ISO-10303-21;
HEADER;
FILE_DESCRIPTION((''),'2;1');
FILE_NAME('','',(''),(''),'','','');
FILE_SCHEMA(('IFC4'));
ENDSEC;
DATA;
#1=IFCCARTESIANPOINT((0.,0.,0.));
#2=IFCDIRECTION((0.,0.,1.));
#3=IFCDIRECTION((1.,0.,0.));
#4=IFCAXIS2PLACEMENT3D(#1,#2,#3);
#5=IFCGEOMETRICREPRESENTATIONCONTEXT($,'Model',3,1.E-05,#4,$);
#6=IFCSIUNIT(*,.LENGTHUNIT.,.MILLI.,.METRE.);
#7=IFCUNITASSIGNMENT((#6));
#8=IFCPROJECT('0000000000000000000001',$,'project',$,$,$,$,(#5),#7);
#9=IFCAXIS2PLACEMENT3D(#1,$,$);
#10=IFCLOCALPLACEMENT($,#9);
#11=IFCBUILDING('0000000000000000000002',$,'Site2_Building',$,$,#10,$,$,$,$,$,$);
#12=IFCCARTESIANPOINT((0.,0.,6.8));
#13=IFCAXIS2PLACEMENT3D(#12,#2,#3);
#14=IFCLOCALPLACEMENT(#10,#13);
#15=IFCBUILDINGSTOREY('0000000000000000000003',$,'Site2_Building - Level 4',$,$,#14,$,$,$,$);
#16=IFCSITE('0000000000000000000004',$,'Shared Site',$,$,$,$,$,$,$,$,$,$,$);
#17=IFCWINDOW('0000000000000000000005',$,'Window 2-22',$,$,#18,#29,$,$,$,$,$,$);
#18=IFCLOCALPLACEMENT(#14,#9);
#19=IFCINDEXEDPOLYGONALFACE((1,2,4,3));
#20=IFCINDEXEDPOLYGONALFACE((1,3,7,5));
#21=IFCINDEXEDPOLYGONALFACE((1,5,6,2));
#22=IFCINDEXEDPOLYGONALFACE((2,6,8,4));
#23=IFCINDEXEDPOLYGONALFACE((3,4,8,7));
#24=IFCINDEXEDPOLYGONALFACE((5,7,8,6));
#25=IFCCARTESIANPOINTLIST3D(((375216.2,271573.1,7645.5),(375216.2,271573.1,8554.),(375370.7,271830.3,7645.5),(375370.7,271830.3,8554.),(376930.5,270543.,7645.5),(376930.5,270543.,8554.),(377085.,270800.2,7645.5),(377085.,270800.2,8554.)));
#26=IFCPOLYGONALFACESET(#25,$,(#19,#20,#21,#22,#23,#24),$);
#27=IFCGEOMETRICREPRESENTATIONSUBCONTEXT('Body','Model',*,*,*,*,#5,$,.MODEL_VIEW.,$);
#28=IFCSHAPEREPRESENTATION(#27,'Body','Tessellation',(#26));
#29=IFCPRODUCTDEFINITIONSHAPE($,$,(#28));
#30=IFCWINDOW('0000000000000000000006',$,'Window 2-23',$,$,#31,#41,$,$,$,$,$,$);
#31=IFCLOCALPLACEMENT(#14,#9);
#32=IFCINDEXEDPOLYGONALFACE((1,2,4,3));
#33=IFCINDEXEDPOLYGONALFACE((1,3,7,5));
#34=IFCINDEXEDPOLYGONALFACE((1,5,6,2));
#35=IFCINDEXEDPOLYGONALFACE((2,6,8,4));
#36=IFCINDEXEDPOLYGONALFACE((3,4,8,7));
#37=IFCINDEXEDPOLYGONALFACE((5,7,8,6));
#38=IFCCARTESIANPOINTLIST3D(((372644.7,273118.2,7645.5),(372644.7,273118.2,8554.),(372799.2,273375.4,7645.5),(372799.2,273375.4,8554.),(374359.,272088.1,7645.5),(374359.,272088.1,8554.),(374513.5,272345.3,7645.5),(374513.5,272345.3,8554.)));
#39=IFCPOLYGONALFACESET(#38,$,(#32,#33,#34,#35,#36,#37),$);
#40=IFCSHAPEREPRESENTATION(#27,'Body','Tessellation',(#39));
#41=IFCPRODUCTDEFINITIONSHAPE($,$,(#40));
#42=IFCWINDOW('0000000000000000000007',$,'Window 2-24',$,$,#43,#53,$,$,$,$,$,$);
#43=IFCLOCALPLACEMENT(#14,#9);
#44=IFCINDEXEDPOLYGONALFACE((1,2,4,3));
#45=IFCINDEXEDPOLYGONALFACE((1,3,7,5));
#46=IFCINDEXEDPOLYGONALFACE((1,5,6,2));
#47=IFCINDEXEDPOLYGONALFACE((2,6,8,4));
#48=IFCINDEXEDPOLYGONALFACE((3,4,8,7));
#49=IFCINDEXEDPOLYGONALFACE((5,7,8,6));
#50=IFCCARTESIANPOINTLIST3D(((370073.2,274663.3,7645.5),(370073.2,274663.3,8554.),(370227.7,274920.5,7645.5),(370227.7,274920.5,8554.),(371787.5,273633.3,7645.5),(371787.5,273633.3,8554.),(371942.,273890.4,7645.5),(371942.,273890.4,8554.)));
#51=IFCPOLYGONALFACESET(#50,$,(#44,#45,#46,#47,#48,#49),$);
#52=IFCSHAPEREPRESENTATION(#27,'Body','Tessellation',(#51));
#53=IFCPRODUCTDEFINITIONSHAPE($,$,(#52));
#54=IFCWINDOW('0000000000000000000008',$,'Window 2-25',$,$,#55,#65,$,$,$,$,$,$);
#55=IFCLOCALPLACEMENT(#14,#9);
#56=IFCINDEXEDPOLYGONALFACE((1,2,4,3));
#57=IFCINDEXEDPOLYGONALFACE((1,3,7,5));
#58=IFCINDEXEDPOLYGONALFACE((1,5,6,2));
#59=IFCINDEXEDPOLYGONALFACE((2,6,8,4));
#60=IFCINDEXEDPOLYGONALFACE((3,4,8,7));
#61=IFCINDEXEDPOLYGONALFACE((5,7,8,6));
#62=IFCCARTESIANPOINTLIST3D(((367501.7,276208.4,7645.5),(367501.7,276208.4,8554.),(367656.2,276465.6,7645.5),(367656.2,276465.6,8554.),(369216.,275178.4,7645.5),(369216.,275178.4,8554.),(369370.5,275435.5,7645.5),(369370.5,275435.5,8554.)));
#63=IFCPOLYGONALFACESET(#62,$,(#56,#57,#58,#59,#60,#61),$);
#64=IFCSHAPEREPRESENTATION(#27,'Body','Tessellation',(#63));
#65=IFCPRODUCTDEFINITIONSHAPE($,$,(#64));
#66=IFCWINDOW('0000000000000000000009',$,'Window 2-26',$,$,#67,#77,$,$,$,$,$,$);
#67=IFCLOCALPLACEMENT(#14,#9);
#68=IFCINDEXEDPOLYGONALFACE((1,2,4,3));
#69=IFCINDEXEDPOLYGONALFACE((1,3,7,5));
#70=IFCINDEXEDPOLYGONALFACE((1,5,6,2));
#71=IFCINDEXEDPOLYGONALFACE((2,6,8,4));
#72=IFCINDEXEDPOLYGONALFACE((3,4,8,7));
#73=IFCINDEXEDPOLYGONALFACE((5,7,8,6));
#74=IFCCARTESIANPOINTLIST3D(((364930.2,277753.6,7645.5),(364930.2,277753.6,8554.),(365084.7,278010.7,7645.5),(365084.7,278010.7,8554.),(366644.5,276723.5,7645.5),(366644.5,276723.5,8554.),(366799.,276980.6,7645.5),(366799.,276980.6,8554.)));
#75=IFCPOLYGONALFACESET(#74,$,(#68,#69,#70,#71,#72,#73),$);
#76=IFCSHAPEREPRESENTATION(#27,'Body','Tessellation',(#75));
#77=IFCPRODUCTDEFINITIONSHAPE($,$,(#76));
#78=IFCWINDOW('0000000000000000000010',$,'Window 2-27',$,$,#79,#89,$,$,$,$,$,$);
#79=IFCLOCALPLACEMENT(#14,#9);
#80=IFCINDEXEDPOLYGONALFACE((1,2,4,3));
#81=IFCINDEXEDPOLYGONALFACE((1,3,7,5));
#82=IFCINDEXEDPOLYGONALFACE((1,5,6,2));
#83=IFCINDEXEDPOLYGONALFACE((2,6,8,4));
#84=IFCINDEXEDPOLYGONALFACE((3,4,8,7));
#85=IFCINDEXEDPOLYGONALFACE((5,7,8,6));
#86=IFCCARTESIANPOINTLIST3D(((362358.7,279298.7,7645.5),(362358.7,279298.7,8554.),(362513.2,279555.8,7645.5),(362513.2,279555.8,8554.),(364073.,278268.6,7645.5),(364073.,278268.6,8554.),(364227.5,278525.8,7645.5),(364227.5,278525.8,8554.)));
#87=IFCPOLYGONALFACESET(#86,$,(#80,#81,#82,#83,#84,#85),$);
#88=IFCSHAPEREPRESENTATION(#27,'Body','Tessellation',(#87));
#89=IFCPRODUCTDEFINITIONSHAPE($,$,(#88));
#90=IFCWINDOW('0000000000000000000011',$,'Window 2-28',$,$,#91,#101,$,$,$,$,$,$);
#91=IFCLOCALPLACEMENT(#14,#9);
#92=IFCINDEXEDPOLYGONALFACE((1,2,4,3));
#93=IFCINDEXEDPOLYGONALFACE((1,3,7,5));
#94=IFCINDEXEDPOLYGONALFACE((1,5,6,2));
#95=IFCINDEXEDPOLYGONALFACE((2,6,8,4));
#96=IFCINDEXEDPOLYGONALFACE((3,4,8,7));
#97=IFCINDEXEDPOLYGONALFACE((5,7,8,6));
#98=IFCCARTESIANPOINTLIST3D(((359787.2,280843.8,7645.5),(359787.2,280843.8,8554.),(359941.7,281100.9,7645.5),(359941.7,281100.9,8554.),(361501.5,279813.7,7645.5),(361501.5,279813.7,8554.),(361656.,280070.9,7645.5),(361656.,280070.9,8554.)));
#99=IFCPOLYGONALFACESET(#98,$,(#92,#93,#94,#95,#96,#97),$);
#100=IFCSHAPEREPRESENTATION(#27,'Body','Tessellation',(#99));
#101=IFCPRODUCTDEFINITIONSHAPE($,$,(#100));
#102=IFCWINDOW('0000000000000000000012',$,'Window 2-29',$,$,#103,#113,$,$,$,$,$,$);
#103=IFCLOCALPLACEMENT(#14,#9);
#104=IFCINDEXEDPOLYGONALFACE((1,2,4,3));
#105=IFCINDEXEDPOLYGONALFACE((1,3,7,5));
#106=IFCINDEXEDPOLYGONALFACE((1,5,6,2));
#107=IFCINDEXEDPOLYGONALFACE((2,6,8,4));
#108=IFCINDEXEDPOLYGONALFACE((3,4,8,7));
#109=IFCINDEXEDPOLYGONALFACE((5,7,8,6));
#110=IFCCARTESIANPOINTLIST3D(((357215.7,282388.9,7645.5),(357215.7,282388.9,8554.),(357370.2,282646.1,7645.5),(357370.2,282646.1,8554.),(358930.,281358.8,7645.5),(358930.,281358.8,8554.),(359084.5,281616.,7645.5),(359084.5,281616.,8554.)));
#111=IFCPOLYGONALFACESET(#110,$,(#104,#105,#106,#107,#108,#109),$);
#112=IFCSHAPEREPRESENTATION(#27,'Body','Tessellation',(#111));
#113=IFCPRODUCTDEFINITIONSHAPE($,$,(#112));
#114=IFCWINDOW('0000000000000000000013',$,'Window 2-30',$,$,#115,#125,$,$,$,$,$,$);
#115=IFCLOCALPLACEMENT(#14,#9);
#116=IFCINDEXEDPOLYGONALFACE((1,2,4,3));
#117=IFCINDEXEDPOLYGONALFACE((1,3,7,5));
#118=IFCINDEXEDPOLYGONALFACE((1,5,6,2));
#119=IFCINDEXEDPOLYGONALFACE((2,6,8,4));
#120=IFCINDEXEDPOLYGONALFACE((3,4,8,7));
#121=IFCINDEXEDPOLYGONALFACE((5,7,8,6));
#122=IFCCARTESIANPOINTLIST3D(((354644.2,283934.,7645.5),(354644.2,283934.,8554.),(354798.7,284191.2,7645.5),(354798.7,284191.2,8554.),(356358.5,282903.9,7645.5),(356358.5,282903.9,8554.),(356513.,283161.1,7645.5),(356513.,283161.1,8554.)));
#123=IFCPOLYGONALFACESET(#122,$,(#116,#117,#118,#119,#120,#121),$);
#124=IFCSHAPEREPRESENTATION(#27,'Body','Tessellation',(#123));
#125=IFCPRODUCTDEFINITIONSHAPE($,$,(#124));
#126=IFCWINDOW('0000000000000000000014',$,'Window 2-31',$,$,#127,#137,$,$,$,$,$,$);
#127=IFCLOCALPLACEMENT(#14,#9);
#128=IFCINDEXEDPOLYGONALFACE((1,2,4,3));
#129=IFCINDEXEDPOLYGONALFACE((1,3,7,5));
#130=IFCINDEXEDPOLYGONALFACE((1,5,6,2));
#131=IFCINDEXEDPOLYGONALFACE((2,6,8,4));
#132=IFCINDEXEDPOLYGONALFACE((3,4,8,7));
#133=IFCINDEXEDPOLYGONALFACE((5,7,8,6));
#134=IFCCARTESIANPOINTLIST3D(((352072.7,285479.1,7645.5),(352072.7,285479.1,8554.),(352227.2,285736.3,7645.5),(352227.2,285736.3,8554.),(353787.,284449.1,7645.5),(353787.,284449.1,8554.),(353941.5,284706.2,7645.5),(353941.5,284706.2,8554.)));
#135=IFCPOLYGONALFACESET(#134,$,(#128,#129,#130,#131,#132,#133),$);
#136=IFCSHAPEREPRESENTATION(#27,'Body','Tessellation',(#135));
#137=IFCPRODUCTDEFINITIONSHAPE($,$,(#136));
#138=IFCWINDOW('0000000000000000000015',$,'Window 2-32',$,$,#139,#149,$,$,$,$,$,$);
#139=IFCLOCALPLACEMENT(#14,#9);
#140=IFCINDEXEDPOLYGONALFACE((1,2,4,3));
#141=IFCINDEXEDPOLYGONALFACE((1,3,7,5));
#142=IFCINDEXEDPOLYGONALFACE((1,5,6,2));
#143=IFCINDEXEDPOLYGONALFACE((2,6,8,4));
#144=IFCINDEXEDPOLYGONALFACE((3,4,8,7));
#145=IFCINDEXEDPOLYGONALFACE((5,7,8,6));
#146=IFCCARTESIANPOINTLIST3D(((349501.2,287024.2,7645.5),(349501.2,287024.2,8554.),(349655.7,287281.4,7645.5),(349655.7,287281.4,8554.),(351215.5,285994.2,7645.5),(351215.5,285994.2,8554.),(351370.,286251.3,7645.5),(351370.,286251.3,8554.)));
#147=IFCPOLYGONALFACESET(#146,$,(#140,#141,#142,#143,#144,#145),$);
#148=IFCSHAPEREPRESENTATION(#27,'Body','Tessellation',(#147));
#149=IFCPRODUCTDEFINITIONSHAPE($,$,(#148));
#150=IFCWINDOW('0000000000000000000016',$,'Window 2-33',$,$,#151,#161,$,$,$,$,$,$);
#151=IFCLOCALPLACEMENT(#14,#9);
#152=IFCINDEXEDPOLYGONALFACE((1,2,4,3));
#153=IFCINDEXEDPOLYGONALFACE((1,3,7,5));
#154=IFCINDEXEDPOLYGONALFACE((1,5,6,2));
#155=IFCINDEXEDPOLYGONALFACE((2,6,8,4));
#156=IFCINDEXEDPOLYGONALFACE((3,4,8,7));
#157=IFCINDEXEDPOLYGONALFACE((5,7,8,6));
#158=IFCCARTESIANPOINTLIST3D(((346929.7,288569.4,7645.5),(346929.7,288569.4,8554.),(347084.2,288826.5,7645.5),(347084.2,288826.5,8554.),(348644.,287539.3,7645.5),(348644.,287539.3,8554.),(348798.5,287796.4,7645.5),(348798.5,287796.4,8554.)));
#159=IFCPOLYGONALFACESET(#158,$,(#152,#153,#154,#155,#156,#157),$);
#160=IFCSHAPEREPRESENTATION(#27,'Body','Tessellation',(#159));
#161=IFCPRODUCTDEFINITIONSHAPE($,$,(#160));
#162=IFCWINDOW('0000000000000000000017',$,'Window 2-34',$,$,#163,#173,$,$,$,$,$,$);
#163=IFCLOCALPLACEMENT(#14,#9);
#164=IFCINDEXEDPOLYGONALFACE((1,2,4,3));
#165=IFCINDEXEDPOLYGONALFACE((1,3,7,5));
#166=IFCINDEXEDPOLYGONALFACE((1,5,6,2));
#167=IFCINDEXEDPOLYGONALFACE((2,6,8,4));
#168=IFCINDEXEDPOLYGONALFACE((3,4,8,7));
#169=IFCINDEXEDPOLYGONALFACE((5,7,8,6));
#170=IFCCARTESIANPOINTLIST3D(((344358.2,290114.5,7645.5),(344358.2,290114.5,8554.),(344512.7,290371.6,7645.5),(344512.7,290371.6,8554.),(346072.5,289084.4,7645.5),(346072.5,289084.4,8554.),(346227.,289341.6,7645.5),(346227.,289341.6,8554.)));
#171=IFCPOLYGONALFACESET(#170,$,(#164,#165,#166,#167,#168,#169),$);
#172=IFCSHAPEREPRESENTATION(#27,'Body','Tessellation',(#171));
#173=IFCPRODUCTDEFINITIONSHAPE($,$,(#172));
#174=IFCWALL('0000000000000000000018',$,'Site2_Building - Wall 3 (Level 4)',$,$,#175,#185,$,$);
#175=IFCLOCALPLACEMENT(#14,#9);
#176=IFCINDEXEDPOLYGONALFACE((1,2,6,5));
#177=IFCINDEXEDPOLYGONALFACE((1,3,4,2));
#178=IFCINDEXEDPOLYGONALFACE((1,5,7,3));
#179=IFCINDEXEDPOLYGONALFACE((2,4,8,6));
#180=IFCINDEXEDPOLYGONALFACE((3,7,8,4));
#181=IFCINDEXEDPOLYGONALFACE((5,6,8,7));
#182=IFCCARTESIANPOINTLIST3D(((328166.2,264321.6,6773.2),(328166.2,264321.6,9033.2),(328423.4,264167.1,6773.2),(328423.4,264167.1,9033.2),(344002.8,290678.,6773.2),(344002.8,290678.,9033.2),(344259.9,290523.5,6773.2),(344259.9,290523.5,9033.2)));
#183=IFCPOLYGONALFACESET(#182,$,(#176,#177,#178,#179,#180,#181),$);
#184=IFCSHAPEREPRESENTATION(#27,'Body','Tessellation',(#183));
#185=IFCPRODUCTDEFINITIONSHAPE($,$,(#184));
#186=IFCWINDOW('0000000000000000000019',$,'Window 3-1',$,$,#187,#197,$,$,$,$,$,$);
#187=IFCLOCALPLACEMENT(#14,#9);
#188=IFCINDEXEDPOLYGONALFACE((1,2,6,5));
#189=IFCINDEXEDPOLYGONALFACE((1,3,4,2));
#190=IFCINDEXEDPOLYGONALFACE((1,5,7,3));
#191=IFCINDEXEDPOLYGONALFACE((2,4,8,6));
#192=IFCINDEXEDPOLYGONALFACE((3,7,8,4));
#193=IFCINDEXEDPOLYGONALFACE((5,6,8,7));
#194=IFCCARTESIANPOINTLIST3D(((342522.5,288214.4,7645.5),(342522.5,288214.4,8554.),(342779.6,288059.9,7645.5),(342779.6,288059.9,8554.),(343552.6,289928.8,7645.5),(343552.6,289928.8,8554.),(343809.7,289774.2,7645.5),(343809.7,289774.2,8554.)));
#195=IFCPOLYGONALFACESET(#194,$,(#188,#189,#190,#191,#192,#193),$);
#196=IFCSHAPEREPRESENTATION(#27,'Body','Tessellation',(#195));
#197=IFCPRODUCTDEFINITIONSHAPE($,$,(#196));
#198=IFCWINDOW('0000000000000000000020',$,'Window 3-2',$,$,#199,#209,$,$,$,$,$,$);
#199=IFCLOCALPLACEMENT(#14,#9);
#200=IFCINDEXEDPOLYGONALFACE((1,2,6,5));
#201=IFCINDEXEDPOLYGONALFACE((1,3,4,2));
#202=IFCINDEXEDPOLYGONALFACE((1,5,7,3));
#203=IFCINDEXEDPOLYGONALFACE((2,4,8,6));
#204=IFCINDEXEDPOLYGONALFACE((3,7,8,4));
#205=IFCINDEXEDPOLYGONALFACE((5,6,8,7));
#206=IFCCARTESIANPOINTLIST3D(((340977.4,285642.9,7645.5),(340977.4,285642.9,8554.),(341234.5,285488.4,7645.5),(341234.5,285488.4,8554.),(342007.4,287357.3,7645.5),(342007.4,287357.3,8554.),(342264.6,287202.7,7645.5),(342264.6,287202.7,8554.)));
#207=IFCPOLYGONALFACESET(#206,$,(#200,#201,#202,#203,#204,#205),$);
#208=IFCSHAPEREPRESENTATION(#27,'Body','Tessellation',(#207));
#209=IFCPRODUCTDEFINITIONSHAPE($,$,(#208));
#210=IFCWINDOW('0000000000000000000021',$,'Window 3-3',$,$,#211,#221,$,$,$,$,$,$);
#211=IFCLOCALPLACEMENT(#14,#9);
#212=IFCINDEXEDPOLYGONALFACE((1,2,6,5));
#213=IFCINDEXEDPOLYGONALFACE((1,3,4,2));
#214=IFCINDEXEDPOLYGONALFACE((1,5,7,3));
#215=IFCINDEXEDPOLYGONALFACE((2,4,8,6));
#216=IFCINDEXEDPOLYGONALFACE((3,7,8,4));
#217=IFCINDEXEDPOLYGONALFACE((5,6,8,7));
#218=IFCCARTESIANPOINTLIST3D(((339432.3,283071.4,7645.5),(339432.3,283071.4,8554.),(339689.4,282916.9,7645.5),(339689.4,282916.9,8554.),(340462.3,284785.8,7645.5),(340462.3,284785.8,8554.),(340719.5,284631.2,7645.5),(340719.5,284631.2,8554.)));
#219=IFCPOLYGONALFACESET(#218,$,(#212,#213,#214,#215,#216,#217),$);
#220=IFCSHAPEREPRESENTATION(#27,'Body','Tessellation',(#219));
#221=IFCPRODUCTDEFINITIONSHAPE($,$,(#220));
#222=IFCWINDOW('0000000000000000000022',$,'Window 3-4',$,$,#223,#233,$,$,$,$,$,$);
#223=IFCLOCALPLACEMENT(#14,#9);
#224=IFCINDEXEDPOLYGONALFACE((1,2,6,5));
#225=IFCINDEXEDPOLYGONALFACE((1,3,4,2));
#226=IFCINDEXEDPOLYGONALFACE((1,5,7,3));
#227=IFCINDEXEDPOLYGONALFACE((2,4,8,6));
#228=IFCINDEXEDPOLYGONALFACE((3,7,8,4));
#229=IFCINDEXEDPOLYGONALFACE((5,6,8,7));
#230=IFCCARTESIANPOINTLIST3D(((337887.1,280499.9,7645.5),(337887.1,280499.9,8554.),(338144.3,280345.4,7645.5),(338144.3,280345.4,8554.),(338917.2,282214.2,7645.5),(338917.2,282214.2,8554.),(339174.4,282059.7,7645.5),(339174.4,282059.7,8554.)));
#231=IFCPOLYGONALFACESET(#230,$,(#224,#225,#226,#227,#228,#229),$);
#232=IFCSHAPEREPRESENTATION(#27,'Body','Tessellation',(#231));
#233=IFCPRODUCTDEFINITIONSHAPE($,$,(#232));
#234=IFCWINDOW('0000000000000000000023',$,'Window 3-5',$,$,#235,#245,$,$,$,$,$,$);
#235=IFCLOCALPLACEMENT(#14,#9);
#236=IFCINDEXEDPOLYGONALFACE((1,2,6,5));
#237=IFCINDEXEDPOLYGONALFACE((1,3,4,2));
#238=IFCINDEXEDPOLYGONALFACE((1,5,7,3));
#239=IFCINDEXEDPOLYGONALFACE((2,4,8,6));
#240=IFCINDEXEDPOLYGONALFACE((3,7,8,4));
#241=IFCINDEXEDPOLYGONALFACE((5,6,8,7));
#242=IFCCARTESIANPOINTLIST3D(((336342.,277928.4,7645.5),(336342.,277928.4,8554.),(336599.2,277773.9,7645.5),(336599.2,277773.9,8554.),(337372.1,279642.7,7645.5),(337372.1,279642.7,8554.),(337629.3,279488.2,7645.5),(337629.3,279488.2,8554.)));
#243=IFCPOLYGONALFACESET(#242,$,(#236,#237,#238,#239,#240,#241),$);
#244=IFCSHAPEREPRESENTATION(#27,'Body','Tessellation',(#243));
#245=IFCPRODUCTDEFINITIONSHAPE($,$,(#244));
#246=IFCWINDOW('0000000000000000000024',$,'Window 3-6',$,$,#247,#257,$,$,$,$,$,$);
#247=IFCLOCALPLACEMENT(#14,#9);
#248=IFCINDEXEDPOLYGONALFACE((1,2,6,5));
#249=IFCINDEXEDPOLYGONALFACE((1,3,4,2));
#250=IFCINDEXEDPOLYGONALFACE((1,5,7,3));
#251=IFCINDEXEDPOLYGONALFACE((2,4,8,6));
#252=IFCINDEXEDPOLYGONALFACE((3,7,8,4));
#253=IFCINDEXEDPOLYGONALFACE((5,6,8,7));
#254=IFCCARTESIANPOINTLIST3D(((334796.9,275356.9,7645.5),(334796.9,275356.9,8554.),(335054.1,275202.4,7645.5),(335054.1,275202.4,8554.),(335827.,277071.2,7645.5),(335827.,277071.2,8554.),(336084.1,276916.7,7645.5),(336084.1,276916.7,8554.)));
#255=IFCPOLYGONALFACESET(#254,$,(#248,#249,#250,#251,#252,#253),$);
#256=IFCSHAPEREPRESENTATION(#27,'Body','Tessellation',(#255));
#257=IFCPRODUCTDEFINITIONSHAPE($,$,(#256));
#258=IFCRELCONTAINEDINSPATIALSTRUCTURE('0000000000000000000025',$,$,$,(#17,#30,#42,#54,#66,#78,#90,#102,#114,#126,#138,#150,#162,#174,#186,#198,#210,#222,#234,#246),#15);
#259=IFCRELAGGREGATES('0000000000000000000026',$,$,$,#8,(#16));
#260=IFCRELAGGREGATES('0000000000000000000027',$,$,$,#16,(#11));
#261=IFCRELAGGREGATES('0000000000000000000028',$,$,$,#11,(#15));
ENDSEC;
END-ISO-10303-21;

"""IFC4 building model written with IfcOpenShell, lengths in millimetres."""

from ifc_helpers import new_model, si_unit, frame, origin, origin_with_axes, place, context, subcontext, project, spatial, indexed_curve, outline, extrude, element, save


model = new_model("IFC4")

# Units and contexts
model_context = context("Model", 3, precision=1e-05, world=origin_with_axes())
body_context = subcontext(model_context, "Body", "Model", "MODEL_VIEW")
ifc_project = project(units=[si_unit("LENGTHUNIT", "METRE", prefix="MILLI")], contexts=[model_context])

# Site, building, storey
site = spatial("IfcSite", under=ifc_project, Name="Shared Site")
building_placement = place(None, origin())
building = spatial("IfcBuilding", under=site, at=building_placement, Name="Site2_Building")
storey_placement = place(building_placement, frame((0.0, 0.0, 6.8), z_axis=(0.0, 0.0, 1.0), x_axis=(1.0, 0.0, 0.0)))
storey = spatial("IfcBuildingStorey", under=building, at=storey_placement, Name="Site2_Building - Level 4")

# Windows
for number, where, z_axis, x_axis, name in (
    (1, (377085.0, 270800.2, 7645.5), (0.0, 0.0, 1.0), (-0.857167, 0.515038, 0.0), "Window 2-22"),
    (2, (374513.5, 272345.3, 7645.5), (0.0, 0.0, 1.0), (-0.857167, 0.515038, 0.0), "Window 2-23"),
    (3, (371942.0, 273890.4, 7645.5), (0.0, 0.0, 1.0), (-0.857167, 0.515038, 0.0), "Window 2-24"),
    (4, (369370.5, 275435.5, 7645.5), (0.0, 0.0, 1.0), (-0.857167, 0.515038, 0.0), "Window 2-25"),
    (5, (366799.0, 276980.6, 7645.5), (0.0, 0.0, 1.0), (-0.857167, 0.515038, 0.0), "Window 2-26"),
    (6, (364227.5, 278525.8, 7645.5), (0.0, 0.0, 1.0), (-0.857167, 0.515038, 0.0), "Window 2-27"),
    (7, (361656.0, 280070.9, 7645.5), (0.0, 0.0, 1.0), (-0.857167, 0.515038, 0.0), "Window 2-28"),
    (8, (359084.5, 281616.0, 7645.5), (0.0, 0.0, 1.0), (-0.857167, 0.515038, 0.0), "Window 2-29"),
    (9, (356513.0, 283161.1, 7645.5), (0.0, 0.0, 1.0), (-0.857167, 0.515038, 0.0), "Window 2-30"),
    (10, (353941.5, 284706.2, 7645.5), (0.0, 0.0, 1.0), (-0.857167, 0.515038, 0.0), "Window 2-31"),
    (11, (351370.0, 286251.3, 7645.5), (0.0, 0.0, 1.0), (-0.857167, 0.515038, 0.0), "Window 2-32"),
    (12, (348798.5, 287796.4, 7645.5), (0.0, 0.0, 1.0), (-0.857167, 0.515038, 0.0), "Window 2-33"),
    (13, (346227.0, 289341.6, 7645.5), (0.0, 0.0, 1.0), (-0.857167, 0.515038, 0.0), "Window 2-34"),
):
    element("IfcWindow", number, at=place(storey_placement, frame(where, z_axis=z_axis, x_axis=x_axis)), inside=storey, Name=name, context=body_context, shape_type="SweptSolid", body=[
        extrude(outline(indexed_curve([(0.0, 0.0), (0.0, 300.0), (2000.0, 300.0), (2000.0, 0.0), (0.0, 0.0)], self_intersect=False)), origin_with_axes(), (0.0, 0.0, 1.0), 908.6),
    ])

# Wall
wall_placement = place(storey_placement, frame((344002.8, 290678.0, 6773.2), z_axis=(0.0, 0.0, 1.0), x_axis=(-0.515038, -0.857167, 0.0)))
element("IfcWall", 14, at=wall_placement, inside=storey, Name="Site2_Building - Wall 3 (Level 4)", context=body_context, shape_type="SweptSolid", body=[
    extrude(outline(indexed_curve([(0.0, 0.0), (0.0, 300.0), (30748.2, 300.0), (30748.2, 0.0), (0.0, 0.0)], self_intersect=False)), origin_with_axes(), (0.0, 0.0, 1.0), 2260.0),
])

# Windows
for number, where, z_axis, x_axis, name in (
    (15, (343552.6, 289928.8, 7645.5), (0.0, 0.0, 1.0), (-0.515038, -0.857167, 0.0), "Window 3-1"),
    (16, (342007.4, 287357.3, 7645.5), (0.0, 0.0, 1.0), (-0.515038, -0.857167, 0.0), "Window 3-2"),
    (17, (340462.3, 284785.8, 7645.5), (0.0, 0.0, 1.0), (-0.515038, -0.857167, 0.0), "Window 3-3"),
    (18, (338917.2, 282214.2, 7645.5), (0.0, 0.0, 1.0), (-0.515038, -0.857167, 0.0), "Window 3-4"),
    (19, (337372.1, 279642.7, 7645.5), (0.0, 0.0, 1.0), (-0.515038, -0.857167, 0.0), "Window 3-5"),
    (20, (335827.0, 277071.2, 7645.5), (0.0, 0.0, 1.0), (-0.515038, -0.857167, 0.0), "Window 3-6"),
):
    element("IfcWindow", number, at=place(storey_placement, frame(where, z_axis=z_axis, x_axis=x_axis)), inside=storey, Name=name, context=body_context, shape_type="SweptSolid", body=[
        extrude(outline(indexed_curve([(0.0, 0.0), (0.0, 300.0), (2000.0, 300.0), (2000.0, 0.0), (0.0, 0.0)], self_intersect=False)), origin_with_axes(), (0.0, 0.0, 1.0), 908.6),
    ])

save(model, "model.ifc")
